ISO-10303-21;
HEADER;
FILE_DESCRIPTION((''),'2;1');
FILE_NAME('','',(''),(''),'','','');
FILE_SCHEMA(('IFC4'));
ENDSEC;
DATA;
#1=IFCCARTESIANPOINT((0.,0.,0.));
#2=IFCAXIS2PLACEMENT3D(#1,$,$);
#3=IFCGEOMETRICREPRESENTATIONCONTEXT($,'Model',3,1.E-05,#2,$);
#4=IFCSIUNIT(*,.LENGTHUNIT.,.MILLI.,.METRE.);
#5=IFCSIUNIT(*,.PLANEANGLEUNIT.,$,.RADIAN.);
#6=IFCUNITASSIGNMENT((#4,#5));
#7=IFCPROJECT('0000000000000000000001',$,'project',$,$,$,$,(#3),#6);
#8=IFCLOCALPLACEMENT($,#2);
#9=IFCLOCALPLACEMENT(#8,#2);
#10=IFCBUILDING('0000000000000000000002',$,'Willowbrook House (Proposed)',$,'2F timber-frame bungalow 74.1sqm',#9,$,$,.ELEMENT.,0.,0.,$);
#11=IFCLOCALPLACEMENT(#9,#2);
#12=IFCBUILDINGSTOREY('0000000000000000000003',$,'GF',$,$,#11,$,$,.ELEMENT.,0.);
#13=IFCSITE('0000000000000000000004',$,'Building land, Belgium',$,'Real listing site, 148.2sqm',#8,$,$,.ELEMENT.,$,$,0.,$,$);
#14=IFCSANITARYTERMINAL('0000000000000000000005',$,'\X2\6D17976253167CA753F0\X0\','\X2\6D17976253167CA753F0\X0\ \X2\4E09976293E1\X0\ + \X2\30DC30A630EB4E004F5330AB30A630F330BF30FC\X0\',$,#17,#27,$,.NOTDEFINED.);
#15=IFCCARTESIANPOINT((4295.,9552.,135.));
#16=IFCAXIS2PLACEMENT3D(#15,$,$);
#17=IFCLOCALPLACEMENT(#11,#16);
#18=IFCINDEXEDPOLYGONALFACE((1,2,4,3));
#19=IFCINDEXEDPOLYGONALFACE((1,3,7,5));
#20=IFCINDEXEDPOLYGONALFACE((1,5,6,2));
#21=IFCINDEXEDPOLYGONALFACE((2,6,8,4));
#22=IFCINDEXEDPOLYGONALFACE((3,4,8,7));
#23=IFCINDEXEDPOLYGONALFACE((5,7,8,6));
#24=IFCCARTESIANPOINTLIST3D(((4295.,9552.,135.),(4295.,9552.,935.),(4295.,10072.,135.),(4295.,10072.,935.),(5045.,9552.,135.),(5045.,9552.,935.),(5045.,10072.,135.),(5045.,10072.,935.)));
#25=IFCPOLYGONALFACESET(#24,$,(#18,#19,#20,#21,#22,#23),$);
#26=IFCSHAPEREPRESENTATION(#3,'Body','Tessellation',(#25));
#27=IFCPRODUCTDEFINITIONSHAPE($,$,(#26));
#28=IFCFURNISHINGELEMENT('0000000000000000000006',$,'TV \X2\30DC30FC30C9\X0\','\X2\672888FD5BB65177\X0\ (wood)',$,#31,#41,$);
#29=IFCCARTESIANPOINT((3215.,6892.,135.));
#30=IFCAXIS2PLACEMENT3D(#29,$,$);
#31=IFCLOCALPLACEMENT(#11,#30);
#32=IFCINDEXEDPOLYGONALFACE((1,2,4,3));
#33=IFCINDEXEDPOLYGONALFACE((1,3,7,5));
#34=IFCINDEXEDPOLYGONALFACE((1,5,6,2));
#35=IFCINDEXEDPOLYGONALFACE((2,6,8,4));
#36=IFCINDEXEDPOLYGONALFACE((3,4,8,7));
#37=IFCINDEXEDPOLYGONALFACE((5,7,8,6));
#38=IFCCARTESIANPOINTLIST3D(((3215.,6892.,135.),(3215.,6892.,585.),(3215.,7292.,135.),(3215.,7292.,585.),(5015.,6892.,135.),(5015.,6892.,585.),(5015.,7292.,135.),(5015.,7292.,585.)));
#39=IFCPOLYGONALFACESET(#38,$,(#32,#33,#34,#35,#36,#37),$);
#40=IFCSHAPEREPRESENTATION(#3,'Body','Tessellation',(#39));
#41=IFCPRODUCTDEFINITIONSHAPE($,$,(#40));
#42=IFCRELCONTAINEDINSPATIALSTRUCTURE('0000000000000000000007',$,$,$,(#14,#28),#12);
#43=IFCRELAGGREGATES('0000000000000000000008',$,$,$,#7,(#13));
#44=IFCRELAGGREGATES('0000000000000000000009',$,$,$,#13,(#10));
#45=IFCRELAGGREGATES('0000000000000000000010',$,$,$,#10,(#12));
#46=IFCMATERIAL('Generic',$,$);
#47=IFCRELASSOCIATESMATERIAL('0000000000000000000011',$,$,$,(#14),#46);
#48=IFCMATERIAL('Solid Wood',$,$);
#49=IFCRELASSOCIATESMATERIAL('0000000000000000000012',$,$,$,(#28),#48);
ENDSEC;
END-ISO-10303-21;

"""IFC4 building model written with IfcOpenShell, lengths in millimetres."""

from ifc_helpers import new_model, si_unit, frame, frame_2d, origin, place, context, project, spatial, rectangle, extrude, material, element, save


model = new_model("IFC4")

# Units and contexts
model_context = context("Model", 3, precision=1e-05, world=origin())
ifc_project = project(units=[si_unit("LENGTHUNIT", "METRE", prefix="MILLI"), si_unit("PLANEANGLEUNIT", "RADIAN")], contexts=[model_context])

# Site, building, storey
site_placement = place(None, origin())
site = spatial("IfcSite", under=ifc_project, at=site_placement, Name="Building land, Belgium", ObjectType="Real listing site, 148.2sqm", CompositionType="ELEMENT", RefElevation=0.0)
building_placement = place(site_placement, origin())
building = spatial("IfcBuilding", under=site, at=building_placement, Name="Willowbrook House (Proposed)", ObjectType="2F timber-frame bungalow 74.1sqm", CompositionType="ELEMENT", ElevationOfRefHeight=0.0, ElevationOfTerrain=0.0)
storey_placement = place(building_placement, origin())
storey = spatial("IfcBuildingStorey", under=building, at=storey_placement, Name="GF", CompositionType="ELEMENT", Elevation=0.0)

# Shared definitions
ifc_material_1 = material(Name="Solid Wood")

# Shared definitions
ifc_material_2 = material(Name="Generic")

# Sanitary terminal
sanitary_terminal_1_placement = place(storey_placement, frame((4295.0, 9552.0, 135.0)))
element("IfcSanitaryTerminal", 1, at=sanitary_terminal_1_placement, inside=storey, material=ifc_material_2, Name="洗面化粧台", Description="洗面化粧台 三面鏡 + ボウル一体カウンター", PredefinedType="NOTDEFINED", context=model_context, shape_type="SweptSolid", body=[
    extrude(rectangle(XDim=750.0, YDim=520.0, at=frame_2d((375.0, 260.0))), frame((4295.0, 9552.0, 135.0)), (0.0, 0.0, 1.0), 800.0),
])

# Furnishing element
furnishing_placement = place(storey_placement, frame((3215.0, 6892.0, 135.0)))
element("IfcFurnishingElement", 2, at=furnishing_placement, inside=storey, material=ifc_material_1, Name="TV ボード", Description="木製家具 (wood)", context=model_context, shape_type="SweptSolid", body=[
    extrude(rectangle(XDim=1800.0, YDim=400.0, at=frame_2d((900.0, 200.0))), frame((3215.0, 6892.0, 135.0)), (0.0, 0.0, 1.0), 450.0),
])

save(model, "model.ifc")
